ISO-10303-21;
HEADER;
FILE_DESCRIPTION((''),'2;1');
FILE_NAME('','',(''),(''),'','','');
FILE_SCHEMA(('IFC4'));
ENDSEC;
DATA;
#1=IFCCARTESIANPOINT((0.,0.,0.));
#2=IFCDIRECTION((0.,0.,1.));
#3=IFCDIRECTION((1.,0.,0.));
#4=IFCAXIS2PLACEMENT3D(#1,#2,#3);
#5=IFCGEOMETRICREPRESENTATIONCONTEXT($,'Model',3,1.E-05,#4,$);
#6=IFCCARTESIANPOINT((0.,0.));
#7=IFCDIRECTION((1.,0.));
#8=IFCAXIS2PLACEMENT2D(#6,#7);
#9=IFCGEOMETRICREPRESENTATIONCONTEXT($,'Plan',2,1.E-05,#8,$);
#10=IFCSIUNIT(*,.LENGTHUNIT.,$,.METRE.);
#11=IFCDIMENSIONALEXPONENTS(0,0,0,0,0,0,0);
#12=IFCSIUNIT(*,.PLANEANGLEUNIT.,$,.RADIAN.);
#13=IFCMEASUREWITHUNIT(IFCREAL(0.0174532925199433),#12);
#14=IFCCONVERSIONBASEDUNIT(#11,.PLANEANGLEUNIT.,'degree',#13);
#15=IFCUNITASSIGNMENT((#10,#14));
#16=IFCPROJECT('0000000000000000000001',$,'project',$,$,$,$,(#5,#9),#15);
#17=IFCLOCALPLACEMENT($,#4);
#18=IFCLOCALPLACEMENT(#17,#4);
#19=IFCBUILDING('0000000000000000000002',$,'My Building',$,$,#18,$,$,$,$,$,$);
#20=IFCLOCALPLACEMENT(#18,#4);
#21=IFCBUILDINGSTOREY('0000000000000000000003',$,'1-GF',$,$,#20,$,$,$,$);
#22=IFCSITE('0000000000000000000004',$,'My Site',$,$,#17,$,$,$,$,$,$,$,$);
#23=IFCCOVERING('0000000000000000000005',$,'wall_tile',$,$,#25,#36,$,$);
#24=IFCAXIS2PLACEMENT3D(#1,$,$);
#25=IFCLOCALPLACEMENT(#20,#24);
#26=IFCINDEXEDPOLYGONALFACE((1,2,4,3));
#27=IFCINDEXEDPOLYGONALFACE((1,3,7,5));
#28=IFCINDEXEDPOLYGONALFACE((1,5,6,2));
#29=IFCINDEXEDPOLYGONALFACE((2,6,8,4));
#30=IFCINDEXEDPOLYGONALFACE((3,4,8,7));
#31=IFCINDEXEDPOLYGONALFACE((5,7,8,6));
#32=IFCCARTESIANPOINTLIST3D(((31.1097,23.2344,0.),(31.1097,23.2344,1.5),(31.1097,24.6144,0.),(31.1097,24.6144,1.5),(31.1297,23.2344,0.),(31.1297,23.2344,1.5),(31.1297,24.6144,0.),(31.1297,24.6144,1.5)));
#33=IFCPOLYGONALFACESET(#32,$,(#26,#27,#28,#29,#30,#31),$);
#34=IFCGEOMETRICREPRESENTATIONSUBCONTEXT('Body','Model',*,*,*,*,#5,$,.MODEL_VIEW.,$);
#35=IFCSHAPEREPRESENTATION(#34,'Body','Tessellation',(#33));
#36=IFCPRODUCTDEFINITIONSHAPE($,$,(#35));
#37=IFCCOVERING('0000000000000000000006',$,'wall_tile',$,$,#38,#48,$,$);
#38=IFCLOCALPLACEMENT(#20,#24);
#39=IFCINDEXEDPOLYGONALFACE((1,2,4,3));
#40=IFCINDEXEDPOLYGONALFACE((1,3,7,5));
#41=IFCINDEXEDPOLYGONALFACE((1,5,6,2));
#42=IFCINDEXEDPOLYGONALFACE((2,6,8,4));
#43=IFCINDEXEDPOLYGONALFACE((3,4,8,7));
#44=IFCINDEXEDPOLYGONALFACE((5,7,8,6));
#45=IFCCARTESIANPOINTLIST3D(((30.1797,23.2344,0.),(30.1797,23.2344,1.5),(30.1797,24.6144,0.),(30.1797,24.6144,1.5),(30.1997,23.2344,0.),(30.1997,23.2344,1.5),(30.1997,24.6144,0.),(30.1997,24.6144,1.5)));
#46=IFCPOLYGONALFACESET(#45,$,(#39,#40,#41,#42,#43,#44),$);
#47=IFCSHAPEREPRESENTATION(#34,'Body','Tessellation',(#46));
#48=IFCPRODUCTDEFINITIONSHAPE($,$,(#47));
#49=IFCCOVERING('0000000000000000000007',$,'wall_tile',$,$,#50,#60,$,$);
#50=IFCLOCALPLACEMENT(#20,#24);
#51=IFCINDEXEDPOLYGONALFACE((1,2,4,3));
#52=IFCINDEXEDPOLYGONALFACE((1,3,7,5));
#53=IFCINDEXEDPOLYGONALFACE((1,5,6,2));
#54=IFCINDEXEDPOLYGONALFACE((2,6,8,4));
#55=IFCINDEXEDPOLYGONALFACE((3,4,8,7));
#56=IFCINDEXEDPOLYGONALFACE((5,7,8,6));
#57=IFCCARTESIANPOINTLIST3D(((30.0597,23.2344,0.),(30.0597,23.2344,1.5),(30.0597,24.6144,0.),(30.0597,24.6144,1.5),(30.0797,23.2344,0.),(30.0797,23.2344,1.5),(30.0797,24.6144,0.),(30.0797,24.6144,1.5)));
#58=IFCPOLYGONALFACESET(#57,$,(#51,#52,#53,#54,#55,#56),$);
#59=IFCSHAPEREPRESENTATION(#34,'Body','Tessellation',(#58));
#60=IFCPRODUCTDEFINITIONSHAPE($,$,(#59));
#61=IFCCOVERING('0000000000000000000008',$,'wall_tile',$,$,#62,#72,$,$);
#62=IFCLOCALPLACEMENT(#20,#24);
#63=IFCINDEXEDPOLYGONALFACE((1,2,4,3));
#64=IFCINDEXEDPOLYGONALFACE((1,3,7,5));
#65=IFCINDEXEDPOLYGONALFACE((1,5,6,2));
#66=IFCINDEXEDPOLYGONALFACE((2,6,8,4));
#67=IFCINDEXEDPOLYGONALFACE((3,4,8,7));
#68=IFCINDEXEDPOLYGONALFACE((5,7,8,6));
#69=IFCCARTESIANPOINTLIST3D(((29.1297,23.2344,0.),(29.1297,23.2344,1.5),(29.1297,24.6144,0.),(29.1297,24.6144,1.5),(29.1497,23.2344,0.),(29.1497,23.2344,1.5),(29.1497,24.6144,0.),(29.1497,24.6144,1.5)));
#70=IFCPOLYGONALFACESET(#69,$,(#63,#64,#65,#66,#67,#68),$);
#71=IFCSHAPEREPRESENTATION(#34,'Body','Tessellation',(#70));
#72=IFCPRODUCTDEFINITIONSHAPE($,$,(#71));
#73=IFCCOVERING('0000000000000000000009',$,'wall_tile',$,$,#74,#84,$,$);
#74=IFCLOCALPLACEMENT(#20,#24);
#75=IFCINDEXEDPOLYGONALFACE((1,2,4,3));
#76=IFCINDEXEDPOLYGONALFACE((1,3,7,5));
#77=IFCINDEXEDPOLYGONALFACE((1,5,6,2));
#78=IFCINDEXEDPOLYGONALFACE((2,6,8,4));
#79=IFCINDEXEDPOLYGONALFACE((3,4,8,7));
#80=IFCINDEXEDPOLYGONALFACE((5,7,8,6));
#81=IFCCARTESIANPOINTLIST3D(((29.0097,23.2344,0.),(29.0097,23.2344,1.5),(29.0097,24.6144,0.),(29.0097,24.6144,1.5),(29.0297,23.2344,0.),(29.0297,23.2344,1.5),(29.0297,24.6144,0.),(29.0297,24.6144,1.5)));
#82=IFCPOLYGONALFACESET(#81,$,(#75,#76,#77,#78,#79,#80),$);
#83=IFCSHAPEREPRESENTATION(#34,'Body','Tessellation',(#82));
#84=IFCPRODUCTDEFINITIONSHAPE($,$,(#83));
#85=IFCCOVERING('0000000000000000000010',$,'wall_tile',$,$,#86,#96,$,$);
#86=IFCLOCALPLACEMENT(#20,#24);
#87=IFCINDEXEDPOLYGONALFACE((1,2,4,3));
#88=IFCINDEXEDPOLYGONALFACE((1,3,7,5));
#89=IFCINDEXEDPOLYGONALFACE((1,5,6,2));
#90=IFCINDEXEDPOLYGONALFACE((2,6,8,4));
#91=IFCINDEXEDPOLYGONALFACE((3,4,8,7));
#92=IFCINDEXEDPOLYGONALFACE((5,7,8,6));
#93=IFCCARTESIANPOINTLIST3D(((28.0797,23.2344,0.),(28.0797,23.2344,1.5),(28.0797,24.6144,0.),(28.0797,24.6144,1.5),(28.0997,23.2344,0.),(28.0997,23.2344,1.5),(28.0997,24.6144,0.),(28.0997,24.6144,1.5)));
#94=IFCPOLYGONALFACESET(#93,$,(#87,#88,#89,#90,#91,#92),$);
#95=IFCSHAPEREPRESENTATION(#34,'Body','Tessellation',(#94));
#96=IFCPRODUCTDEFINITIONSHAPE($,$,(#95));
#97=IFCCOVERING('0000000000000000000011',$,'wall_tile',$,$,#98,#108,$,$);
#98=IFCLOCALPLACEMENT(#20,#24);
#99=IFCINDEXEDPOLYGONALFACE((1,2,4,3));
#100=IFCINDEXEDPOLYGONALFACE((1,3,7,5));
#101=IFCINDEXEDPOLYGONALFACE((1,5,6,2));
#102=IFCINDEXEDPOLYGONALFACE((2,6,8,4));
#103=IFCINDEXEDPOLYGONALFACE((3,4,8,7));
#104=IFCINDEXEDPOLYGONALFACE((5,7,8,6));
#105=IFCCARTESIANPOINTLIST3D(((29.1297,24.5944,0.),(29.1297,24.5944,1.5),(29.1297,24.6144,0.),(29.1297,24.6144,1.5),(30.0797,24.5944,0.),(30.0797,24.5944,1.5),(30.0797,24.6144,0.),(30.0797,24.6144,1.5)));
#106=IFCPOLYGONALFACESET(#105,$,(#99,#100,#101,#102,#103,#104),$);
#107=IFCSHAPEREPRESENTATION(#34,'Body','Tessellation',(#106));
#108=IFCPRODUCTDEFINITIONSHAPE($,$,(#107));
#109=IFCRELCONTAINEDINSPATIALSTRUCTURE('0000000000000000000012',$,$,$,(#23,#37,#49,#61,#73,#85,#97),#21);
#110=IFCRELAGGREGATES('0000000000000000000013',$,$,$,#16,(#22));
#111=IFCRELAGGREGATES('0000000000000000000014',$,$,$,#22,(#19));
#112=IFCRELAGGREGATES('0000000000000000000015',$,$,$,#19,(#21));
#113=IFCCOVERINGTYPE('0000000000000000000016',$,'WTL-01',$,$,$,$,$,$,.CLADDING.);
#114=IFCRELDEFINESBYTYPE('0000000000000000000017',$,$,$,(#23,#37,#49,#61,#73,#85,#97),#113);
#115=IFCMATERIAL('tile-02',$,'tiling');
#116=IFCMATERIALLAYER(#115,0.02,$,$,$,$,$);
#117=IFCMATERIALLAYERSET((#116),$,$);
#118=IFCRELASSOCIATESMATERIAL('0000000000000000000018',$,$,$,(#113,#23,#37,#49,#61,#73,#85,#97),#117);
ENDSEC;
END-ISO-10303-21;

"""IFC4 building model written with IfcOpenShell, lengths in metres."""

from ifc_helpers import new_model, entity, si_unit, converted_unit, frame, origin_with_axes, origin_2d_with_axis, place, context, subcontext, project, spatial, indexed_curve, outline, extrude, material, layer, layer_set, layer_usage, type_object, element, save


model = new_model("IFC4")

# Units and contexts
model_context = context("Model", 3, precision=1e-05, world=origin_with_axes())
plan_context = context("Plan", 2, precision=1e-05, world=origin_2d_with_axis())
body_context_1 = subcontext(model_context, "Body", "Model", "MODEL_VIEW")
ifc_project = project(units=[si_unit("LENGTHUNIT", "METRE"), converted_unit("PLANEANGLEUNIT", "degree", entity("IfcReal", 0.0174532925199433), si_unit("PLANEANGLEUNIT", "RADIAN"), dimensions=[0, 0, 0, 0, 0, 0, 0])], contexts=[model_context, plan_context])

# Site, building, storey
site_placement = place(None, origin_with_axes())
site = spatial("IfcSite", under=ifc_project, at=site_placement, Name="My Site")
building_placement = place(site_placement, origin_with_axes())
building = spatial("IfcBuilding", under=site, at=building_placement, Name="My Building")
storey_placement = place(building_placement, origin_with_axes())
storey = spatial("IfcBuildingStorey", under=building, at=storey_placement, Name="1-GF")

# Coverings
ifc_material_1 = material(Name="tile-02", Category="tiling")
ifc_layer_1 = layer(ifc_material_1, 0.02)
ifc_layer_set_1 = layer_set([ifc_layer_1])
covering_type_1 = type_object("IfcCoveringType", Name="WTL-01", PredefinedType="CLADDING", material=ifc_layer_set_1)
ifc_layer_usage_1 = layer_usage(ifc_layer_set_1, "AXIS2", "POSITIVE", 0.0)
covering_1_placement = place(storey_placement, frame((31.1297, 23.2344, 0.0), z_axis=(0.0, 0.0, 1.0), x_axis=(0.000001, 1.0, 0.0)))
element("IfcCovering", 1, at=covering_1_placement, inside=storey, type_object=covering_type_1, material=ifc_layer_usage_1, Name="wall_tile", context=body_context_1, shape_type="SweptSolid", body=[
    extrude(outline(indexed_curve([(0.0, 0.0), (0.0, 0.02), (1.38, 0.02), (1.38, 0.0), (0.0, 0.0)], self_intersect=False)), origin_with_axes(), (0.0, 0.0, 1.0), 1.5),
])
ifc_layer_usage_2 = layer_usage(ifc_layer_set_1, "AXIS2", "POSITIVE", 0.0)
covering_2_placement = place(storey_placement, frame((30.1997, 23.2344, 0.0), z_axis=(0.0, 0.0, 1.0), x_axis=(0.000001, 1.0, 0.0)))
element("IfcCovering", 2, at=covering_2_placement, inside=storey, type_object=covering_type_1, material=ifc_layer_usage_2, Name="wall_tile", context=body_context_1, shape_type="SweptSolid", body=[
    extrude(outline(indexed_curve([(0.0, 0.0), (0.0, 0.02), (1.38, 0.02), (1.38, 0.0), (0.0, 0.0)], self_intersect=False)), origin_with_axes(), (0.0, 0.0, 1.0), 1.5),
])
ifc_layer_usage_3 = layer_usage(ifc_layer_set_1, "AXIS2", "POSITIVE", 0.0)
covering_3_placement = place(storey_placement, frame((30.0797, 23.2344, 0.0), z_axis=(0.0, 0.0, 1.0), x_axis=(0.000001, 1.0, 0.0)))
element("IfcCovering", 3, at=covering_3_placement, inside=storey, type_object=covering_type_1, material=ifc_layer_usage_3, Name="wall_tile", context=body_context_1, shape_type="SweptSolid", body=[
    extrude(outline(indexed_curve([(0.0, 0.0), (0.0, 0.02), (1.38, 0.02), (1.38, 0.0), (0.0, 0.0)], self_intersect=False)), origin_with_axes(), (0.0, 0.0, 1.0), 1.5),
])
ifc_layer_usage_4 = layer_usage(ifc_layer_set_1, "AXIS2", "POSITIVE", 0.0)
covering_4_placement = place(storey_placement, frame((29.1497, 23.2344, 0.0), z_axis=(0.0, 0.0, 1.0), x_axis=(0.000001, 1.0, 0.0)))
element("IfcCovering", 4, at=covering_4_placement, inside=storey, type_object=covering_type_1, material=ifc_layer_usage_4, Name="wall_tile", context=body_context_1, shape_type="SweptSolid", body=[
    extrude(outline(indexed_curve([(0.0, 0.0), (0.0, 0.02), (1.38, 0.02), (1.38, 0.0), (0.0, 0.0)], self_intersect=False)), origin_with_axes(), (0.0, 0.0, 1.0), 1.5),
])
ifc_layer_usage_5 = layer_usage(ifc_layer_set_1, "AXIS2", "POSITIVE", 0.0)
covering_5_placement = place(storey_placement, frame((29.0297, 23.2344, 0.0), z_axis=(0.0, 0.0, 1.0), x_axis=(0.000001, 1.0, 0.0)))
element("IfcCovering", 5, at=covering_5_placement, inside=storey, type_object=covering_type_1, material=ifc_layer_usage_5, Name="wall_tile", context=body_context_1, shape_type="SweptSolid", body=[
    extrude(outline(indexed_curve([(0.0, 0.0), (0.0, 0.02), (1.38, 0.02), (1.38, 0.0), (0.0, 0.0)], self_intersect=False)), origin_with_axes(), (0.0, 0.0, 1.0), 1.5),
])
ifc_layer_usage_6 = layer_usage(ifc_layer_set_1, "AXIS2", "POSITIVE", 0.0)
covering_6_placement = place(storey_placement, frame((28.0997, 23.2344, 0.0), z_axis=(0.0, 0.0, 1.0), x_axis=(0.000001, 1.0, 0.0)))
element("IfcCovering", 6, at=covering_6_placement, inside=storey, type_object=covering_type_1, material=ifc_layer_usage_6, Name="wall_tile", context=body_context_1, shape_type="SweptSolid", body=[
    extrude(outline(indexed_curve([(0.0, 0.0), (0.0, 0.02), (1.38, 0.02), (1.38, 0.0), (0.0, 0.0)], self_intersect=False)), origin_with_axes(), (0.0, 0.0, 1.0), 1.5),
])
ifc_layer_usage_7 = layer_usage(ifc_layer_set_1, "AXIS2", "POSITIVE", 0.0)
covering_7_placement = place(storey_placement, frame((30.0797, 24.6144, 0.0), z_axis=(0.0, 0.0, 1.0), x_axis=(-1.0, 0.000001, 0.0)))
element("IfcCovering", 7, at=covering_7_placement, inside=storey, type_object=covering_type_1, material=ifc_layer_usage_7, Name="wall_tile", context=body_context_1, shape_type="SweptSolid", body=[
    extrude(outline(indexed_curve([(0.0, 0.0), (0.0, 0.02), (0.95, 0.02), (0.95, 0.0), (0.0, 0.0)], self_intersect=False)), origin_with_axes(), (0.0, 0.0, 1.0), 1.5),
])

save(model, "model.ifc")
